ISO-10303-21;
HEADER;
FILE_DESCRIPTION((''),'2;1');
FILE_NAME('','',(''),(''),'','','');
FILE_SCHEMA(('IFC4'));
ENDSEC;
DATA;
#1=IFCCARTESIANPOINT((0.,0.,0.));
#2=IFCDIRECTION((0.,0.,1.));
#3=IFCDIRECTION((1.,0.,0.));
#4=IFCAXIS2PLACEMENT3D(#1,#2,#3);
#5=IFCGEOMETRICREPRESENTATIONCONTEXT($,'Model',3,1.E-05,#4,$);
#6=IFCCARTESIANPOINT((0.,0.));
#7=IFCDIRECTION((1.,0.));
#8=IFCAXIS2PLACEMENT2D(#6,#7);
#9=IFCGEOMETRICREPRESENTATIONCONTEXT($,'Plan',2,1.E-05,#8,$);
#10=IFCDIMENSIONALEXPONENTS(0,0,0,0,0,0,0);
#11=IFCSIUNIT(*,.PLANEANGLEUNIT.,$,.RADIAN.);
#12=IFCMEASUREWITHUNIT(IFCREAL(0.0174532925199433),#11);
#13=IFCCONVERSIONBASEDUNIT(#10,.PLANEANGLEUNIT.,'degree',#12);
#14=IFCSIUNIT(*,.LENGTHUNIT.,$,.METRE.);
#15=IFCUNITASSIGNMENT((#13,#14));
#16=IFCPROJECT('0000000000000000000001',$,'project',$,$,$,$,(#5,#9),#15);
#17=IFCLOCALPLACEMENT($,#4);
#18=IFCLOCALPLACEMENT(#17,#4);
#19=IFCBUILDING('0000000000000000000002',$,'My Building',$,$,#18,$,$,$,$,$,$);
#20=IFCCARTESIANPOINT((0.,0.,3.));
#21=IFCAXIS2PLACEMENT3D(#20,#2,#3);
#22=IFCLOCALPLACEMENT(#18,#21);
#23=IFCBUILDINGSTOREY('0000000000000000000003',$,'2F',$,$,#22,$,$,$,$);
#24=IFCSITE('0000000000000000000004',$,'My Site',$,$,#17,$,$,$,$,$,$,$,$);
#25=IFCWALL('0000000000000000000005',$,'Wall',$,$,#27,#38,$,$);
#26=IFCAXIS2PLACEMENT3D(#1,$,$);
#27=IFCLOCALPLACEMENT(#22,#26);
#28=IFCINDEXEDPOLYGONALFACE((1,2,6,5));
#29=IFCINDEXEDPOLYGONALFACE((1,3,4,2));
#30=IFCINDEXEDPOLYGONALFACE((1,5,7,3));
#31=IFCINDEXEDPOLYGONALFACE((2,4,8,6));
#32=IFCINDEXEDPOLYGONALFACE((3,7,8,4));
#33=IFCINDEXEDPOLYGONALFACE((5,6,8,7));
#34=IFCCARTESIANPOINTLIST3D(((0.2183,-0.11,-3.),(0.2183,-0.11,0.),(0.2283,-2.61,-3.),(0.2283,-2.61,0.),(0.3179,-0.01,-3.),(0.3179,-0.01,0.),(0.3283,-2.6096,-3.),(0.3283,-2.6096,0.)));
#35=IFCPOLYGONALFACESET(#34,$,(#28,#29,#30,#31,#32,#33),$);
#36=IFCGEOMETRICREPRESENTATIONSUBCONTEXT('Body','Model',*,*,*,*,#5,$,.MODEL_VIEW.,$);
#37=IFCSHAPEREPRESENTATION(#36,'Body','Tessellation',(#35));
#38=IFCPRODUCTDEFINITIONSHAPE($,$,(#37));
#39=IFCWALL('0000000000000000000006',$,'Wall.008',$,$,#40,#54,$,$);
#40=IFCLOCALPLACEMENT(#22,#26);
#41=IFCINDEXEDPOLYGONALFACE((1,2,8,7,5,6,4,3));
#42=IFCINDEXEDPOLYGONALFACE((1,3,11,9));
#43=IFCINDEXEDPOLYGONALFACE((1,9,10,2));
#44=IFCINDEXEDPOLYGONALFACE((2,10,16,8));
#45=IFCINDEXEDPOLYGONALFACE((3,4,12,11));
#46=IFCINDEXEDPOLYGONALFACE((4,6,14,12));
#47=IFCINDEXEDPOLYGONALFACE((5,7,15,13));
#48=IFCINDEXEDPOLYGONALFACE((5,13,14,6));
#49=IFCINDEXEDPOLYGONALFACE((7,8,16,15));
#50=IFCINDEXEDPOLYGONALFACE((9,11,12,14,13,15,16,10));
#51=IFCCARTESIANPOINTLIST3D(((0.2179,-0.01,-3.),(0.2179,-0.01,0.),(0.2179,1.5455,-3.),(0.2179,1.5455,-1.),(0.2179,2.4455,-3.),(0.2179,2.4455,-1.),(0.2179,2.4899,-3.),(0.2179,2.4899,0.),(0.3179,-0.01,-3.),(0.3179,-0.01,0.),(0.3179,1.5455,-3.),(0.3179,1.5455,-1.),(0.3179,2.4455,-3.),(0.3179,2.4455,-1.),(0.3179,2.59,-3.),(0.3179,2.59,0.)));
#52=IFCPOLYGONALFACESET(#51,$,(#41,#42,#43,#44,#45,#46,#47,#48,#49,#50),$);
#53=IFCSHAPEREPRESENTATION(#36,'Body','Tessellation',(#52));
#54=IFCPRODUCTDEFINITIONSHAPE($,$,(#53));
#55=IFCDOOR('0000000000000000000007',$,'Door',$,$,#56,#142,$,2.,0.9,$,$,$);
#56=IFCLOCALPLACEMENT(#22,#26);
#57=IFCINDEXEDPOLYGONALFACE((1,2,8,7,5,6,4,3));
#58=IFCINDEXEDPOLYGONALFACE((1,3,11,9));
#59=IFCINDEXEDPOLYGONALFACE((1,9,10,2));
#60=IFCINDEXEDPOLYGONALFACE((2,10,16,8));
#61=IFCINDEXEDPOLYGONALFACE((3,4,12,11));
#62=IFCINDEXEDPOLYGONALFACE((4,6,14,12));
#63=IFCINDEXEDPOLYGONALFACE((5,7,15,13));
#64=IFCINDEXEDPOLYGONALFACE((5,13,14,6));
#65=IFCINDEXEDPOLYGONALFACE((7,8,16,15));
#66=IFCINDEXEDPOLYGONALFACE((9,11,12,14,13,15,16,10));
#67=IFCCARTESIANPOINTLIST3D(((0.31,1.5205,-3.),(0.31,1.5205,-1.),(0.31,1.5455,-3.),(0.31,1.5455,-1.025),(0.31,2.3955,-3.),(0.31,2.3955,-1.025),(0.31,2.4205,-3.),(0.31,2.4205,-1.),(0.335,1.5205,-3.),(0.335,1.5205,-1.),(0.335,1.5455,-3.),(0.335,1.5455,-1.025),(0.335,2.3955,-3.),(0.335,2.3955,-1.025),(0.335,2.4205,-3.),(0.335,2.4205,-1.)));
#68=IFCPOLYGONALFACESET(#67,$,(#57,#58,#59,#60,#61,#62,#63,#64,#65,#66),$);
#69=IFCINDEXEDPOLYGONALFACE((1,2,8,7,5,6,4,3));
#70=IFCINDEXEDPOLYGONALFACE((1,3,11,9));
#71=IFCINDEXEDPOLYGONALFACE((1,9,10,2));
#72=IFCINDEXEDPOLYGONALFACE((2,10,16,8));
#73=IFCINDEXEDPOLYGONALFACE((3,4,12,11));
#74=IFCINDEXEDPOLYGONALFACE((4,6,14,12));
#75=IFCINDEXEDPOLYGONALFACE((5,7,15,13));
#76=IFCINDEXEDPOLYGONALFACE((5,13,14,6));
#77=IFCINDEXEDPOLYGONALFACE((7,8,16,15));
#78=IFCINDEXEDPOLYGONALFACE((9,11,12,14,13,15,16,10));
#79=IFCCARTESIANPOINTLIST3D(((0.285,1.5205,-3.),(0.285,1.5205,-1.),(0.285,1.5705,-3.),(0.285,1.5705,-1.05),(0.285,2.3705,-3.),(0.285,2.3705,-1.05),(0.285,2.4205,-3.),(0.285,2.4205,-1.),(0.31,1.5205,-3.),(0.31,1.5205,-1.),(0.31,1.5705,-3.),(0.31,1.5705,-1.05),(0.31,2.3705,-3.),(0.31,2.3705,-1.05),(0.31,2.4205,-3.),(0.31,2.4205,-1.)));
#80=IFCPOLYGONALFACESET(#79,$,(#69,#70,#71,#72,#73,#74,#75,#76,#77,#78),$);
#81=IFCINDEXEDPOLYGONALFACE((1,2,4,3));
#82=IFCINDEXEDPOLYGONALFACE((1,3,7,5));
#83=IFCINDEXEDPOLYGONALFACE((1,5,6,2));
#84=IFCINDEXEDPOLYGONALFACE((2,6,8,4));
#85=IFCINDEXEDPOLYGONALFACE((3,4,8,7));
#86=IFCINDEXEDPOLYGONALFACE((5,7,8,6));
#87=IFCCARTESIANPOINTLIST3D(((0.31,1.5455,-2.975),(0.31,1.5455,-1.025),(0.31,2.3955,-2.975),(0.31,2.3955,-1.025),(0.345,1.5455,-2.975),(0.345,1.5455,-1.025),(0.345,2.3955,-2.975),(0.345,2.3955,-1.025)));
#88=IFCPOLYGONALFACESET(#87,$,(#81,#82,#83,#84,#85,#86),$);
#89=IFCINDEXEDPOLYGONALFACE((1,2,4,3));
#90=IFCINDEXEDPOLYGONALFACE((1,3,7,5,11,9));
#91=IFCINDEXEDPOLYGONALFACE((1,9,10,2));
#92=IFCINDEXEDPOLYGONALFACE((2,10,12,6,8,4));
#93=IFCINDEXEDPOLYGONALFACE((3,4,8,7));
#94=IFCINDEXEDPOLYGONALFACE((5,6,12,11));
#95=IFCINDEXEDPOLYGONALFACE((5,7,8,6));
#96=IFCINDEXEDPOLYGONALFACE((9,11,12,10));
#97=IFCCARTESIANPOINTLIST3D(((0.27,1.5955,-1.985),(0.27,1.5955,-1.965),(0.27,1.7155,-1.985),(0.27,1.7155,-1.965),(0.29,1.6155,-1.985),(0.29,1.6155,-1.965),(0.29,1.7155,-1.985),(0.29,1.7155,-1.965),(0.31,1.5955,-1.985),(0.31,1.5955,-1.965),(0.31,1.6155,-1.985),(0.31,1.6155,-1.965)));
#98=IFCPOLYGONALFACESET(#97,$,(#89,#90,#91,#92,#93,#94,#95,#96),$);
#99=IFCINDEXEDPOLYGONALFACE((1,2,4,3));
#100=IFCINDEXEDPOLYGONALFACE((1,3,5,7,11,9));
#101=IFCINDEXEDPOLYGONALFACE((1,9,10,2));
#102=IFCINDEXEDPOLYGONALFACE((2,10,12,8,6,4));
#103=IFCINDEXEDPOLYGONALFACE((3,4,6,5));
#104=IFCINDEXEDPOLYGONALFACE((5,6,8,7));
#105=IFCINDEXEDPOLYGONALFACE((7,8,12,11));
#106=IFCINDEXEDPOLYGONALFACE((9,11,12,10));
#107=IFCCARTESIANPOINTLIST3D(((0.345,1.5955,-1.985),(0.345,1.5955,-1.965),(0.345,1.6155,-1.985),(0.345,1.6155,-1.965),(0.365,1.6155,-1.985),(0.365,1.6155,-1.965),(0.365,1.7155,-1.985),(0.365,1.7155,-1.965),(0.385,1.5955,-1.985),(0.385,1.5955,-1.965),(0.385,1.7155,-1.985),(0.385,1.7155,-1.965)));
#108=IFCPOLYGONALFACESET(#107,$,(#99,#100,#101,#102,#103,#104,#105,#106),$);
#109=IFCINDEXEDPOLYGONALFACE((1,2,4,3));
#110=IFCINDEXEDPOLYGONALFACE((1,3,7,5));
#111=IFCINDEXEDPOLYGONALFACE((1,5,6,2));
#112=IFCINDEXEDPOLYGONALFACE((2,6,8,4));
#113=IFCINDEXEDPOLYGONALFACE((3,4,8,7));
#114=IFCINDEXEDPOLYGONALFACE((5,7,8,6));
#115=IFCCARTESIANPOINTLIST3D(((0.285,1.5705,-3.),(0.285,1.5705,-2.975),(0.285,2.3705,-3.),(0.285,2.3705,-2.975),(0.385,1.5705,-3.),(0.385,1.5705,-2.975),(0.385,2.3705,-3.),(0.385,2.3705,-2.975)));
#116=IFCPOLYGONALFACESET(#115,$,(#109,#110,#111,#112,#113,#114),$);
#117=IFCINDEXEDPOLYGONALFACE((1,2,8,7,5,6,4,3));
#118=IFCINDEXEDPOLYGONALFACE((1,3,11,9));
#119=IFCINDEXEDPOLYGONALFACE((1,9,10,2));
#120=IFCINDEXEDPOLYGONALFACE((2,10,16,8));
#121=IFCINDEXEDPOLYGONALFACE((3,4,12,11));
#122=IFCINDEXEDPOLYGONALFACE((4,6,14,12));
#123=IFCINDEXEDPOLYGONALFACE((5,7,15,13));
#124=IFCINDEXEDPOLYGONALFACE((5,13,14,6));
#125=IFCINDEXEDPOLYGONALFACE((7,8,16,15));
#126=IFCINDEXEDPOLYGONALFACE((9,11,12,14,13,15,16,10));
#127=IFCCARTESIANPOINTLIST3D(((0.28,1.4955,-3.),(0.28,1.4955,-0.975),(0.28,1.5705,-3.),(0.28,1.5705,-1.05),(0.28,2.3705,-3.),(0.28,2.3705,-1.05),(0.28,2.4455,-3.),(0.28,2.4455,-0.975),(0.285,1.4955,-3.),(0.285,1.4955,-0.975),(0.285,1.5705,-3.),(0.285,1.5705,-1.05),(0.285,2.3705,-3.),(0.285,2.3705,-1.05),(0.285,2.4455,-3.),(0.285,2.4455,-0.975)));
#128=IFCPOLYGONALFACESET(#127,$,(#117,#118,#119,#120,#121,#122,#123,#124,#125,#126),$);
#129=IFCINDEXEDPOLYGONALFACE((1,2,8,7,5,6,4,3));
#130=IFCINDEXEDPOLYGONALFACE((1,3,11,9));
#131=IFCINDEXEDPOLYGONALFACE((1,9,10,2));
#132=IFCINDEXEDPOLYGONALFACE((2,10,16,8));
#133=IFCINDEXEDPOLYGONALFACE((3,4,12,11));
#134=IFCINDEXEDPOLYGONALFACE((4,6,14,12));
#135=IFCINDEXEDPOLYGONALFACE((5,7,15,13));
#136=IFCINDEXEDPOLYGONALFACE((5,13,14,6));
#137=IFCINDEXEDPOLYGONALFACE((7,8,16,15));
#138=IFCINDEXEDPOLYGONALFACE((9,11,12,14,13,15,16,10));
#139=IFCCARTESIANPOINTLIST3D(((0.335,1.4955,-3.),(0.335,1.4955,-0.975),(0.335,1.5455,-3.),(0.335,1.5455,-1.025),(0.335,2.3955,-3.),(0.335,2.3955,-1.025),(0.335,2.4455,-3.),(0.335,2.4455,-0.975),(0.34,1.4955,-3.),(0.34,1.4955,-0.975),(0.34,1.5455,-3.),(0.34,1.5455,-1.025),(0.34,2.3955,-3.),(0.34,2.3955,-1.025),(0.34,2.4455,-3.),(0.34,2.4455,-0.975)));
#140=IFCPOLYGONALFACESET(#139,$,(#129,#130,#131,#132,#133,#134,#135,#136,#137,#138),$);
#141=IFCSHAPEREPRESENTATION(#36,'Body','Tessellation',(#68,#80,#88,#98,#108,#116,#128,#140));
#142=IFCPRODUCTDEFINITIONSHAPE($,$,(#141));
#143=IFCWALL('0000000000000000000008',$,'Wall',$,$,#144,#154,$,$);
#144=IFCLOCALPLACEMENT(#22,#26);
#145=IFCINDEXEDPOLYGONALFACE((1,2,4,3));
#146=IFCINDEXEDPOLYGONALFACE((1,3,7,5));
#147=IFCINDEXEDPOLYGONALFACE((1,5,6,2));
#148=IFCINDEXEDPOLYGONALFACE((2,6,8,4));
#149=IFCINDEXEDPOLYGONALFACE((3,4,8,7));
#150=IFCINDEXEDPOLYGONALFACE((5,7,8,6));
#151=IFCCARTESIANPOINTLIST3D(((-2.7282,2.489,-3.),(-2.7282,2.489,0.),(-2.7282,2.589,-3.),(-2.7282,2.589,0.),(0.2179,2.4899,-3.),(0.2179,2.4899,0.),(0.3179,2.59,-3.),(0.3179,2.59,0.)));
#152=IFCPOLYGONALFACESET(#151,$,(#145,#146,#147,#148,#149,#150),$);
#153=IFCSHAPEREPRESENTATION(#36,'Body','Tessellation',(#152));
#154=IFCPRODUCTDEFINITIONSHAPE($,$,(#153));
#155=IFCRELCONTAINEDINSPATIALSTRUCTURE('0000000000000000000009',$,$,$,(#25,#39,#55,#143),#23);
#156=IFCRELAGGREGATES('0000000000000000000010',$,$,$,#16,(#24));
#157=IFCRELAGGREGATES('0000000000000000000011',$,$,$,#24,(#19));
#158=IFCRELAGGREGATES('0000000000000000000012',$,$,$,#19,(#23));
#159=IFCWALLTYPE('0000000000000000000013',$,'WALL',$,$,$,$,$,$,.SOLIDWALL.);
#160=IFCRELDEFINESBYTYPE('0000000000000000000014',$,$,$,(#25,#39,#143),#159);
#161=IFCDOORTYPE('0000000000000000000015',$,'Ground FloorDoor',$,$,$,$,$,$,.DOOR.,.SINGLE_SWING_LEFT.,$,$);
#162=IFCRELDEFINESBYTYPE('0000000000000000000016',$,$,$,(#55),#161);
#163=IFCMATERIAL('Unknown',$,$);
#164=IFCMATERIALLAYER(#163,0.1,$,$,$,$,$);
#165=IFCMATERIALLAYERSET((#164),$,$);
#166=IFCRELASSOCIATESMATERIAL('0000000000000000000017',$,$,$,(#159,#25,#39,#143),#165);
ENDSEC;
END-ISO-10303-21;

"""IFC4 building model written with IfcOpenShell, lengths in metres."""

from ifc_helpers import new_model, entity, si_unit, converted_unit, frame, origin_with_axes, origin_2d_with_axis, place, context, subcontext, project, spatial, line, indexed_curve, outline, extrude, shape, source, transform, mapped, material, layer, layer_set, layer_usage, type_object, type_shapes, element, fill, save


model = new_model("IFC4")

# Units and contexts
model_context = context("Model", 3, precision=1e-05, world=origin_with_axes())
plan_context = context("Plan", 2, precision=1e-05, world=origin_2d_with_axis())
body_context_1 = subcontext(model_context, "Body", "Model", "MODEL_VIEW")
body_context_2 = subcontext(plan_context, "Body", "Plan", "PLAN_VIEW")
ifc_project = project(units=[converted_unit("PLANEANGLEUNIT", "degree", entity("IfcReal", 0.0174532925199433), si_unit("PLANEANGLEUNIT", "RADIAN"), dimensions=[0, 0, 0, 0, 0, 0, 0]), si_unit("LENGTHUNIT", "METRE")], contexts=[model_context, plan_context])

# Site, building, storey
site_placement = place(None, origin_with_axes())
site = spatial("IfcSite", under=ifc_project, at=site_placement, Name="My Site")
building_placement = place(site_placement, origin_with_axes())
building = spatial("IfcBuilding", under=site, at=building_placement, Name="My Building")
storey_placement = place(building_placement, frame((0.0, 0.0, 3.0), z_axis=(0.0, 0.0, 1.0), x_axis=(1.0, 0.0, 0.0)))
storey = spatial("IfcBuildingStorey", under=building, at=storey_placement, Name="2F")

# Shared definitions
ifc_material = material(Name="Unknown")

# Shared definitions
ifc_layer_1 = layer(ifc_material, 0.1)
ifc_layer_set_1 = layer_set([ifc_layer_1])
wall_type_1 = type_object("IfcWallType", Name="WALL", PredefinedType="SOLIDWALL", material=ifc_layer_set_1)

# Wall
ifc_layer_usage_1 = layer_usage(ifc_layer_set_1, "AXIS2", "POSITIVE", 0.0)
wall_1_placement = place(storey_placement, frame((0.2183, -0.11, -3.0), z_axis=(0.0, 0.0, 1.0), x_axis=(0.004, -0.999992, 0.0)))
element("IfcWall", 1, at=wall_1_placement, inside=storey, type_object=wall_type_1, material=ifc_layer_usage_1, Name="Wall", context=body_context_1, shape_type="SweptSolid", body=[
    extrude(outline(indexed_curve([(0.0, 0.0), (-0.0996, 0.1), (2.5, 0.1), (2.5, 0.0)], segments=[line(1, 2, 3, 4, 1)])), origin_with_axes(), (0.0, 0.0, 1.0), 3.0),
])

# Wall, opening, door
ifc_layer_usage_2 = layer_usage(ifc_layer_set_1, "AXIS2", "POSITIVE", 0.0)
wall_2_placement = place(storey_placement, frame((0.3179, -0.01, -3.0), z_axis=(0.0, 0.0, 1.0), x_axis=(0.0, 1.0, 0.0)))
wall_2 = element("IfcWall", 2, at=wall_2_placement, inside=storey, type_object=wall_type_1, material=ifc_layer_usage_2, Name="Wall.008", context=body_context_1, shape_type="SweptSolid", body=[
    extrude(outline(indexed_curve([(0.0, 0.0), (0.0, 0.1), (2.5, 0.1), (2.6, 0.0)], segments=[line(1, 2, 3, 4, 1)])), origin_with_axes(), (0.0, 0.0, 1.0), 3.0),
])
shared_shape_1 = source(origin_with_axes(), body_context_1, "Body", "SweptSolid", [
    extrude(outline(indexed_curve([(0.0, 0.0), (0.9, 0.0), (0.9, 2.0), (0.0, 2.0)], segments=[line(1, 2, 3, 4, 1)])), frame((0.0, -0.6, 0.0), z_axis=(0.0, -1.0, 0.0), x_axis=(1.0, 0.0, 0.0)), (0.0, 0.0, -1.0), 1.2),
])
opening_1_placement = place(wall_2_placement, frame((1.5555, 0.0, 0.0), z_axis=(0.0, 0.0, 1.0), x_axis=(1.0, 0.0, 0.0)))
opening_1 = element("IfcOpeningElement", 3, at=opening_1_placement, cuts=wall_2, PredefinedType="OPENING", context=body_context_1, shape_type="MappedRepresentation", body=[
    mapped(shared_shape_1, transform((0.0, 0.0, 0.0), x_axis=(1.0, 0.0, 0.0), y_axis=(0.0, 1.0, 0.0), z_axis=(0.0, 0.0, 1.0), scale=1.0)),
])
door_type_1 = type_object("IfcDoorType", Name="Ground FloorDoor", OperationType="SINGLE_SWING_LEFT", PredefinedType="DOOR")
shared_shape_2 = source(origin_with_axes(), body_context_1, "Body", "SweptSolid", [
    extrude(outline(indexed_curve([(0.0, 0.0), (0.0, 2.0), (0.9, 2.0), (0.9, 0.0), (0.875, 0.0), (0.875, 1.975), (0.025, 1.975), (0.025, 0.0)], segments=[line(1, 2, 3, 4, 5, 6, 7, 8, 1)])), frame((0.0, 0.025, 0.0), z_axis=(0.0, -1.0, 0.0), x_axis=(1.0, 0.0, 0.0)), (0.0, 0.0, -1.0), 0.025),
    extrude(outline(indexed_curve([(0.0, 0.0), (0.0, 2.0), (0.9, 2.0), (0.9, 0.0), (0.85, 0.0), (0.85, 1.95), (0.05, 1.95), (0.05, 0.0)], segments=[line(1, 2, 3, 4, 5, 6, 7, 8, 1)])), frame((0.0, 0.0, 0.0), z_axis=(0.0, -1.0, 0.0), x_axis=(1.0, 0.0, 0.0)), (0.0, 0.0, -1.0), 0.025),
    extrude(outline(indexed_curve([(0.0, 0.0), (0.85, 0.0), (0.85, 0.035), (0.0, 0.035)], segments=[line(1, 2, 3, 4, 1)])), frame((0.025, 0.025, 0.025), z_axis=(0.0, 0.0, 1.0), x_axis=(1.0, 0.0, 0.0)), (0.0, 0.0, 1.0), 1.95),
    extrude(outline(indexed_curve([(0.0, 0.0), (0.0, -0.04), (-0.12, -0.04), (-0.12, -0.02), (-0.02, -0.02), (-0.02, 0.0)], segments=[line(1, 2, 3, 4, 5, 6, 1)])), frame((0.825, 0.025, 1.015), z_axis=(0.0, 0.0, 1.0), x_axis=(1.0, 0.0, 0.0)), (0.0, 0.0, 1.0), 0.02),
    extrude(outline(indexed_curve([(0.0, 0.0), (0.0, 0.04), (-0.12, 0.04), (-0.12, 0.02), (-0.02, 0.02), (-0.02, 0.0)], segments=[line(1, 2, 3, 4, 5, 6, 1)])), frame((0.825, 0.06, 1.015), z_axis=(0.0, 0.0, 1.0), x_axis=(1.0, 0.0, 0.0)), (0.0, 0.0, 1.0), 0.02),
    extrude(outline(indexed_curve([(0.0, 0.0), (0.8, 0.0), (0.8, 0.1), (0.0, 0.1)], segments=[line(1, 2, 3, 4, 1)])), frame((0.05, 0.0, 0.0), z_axis=(0.0, 0.0, 1.0), x_axis=(1.0, 0.0, 0.0)), (0.0, 0.0, 1.0), 0.025),
    extrude(outline(indexed_curve([(0.0, 0.0), (0.0, 2.025), (0.95, 2.025), (0.95, 0.0), (0.875, 0.0), (0.875, 1.95), (0.075, 1.95), (0.075, 0.0)], segments=[line(1, 2, 3, 4, 5, 6, 7, 8, 1)])), frame((-0.025, -0.005, 0.0), z_axis=(0.0, -1.0, 0.0), x_axis=(1.0, 0.0, 0.0)), (0.0, 0.0, -1.0), 0.005),
    extrude(outline(indexed_curve([(0.0, 0.0), (0.0, 2.025), (0.95, 2.025), (0.95, 0.0), (0.9, 0.0), (0.9, 1.975), (0.05, 1.975), (0.05, 0.0)], segments=[line(1, 2, 3, 4, 5, 6, 7, 8, 1)])), frame((-0.025, 0.05, 0.0), z_axis=(0.0, -1.0, 0.0), x_axis=(1.0, 0.0, 0.0)), (0.0, 0.0, -1.0), 0.005),
])
shared_shape_3 = source(origin_with_axes(), body_context_2, "Body", "Curve2D", [
    entity("IfcIndexedPolyCurve", entity("IfcCartesianPointList2D", [[0.0, 0.0], [0.0, 0.05], [0.025, 0.05], [0.025, 0.025], [0.05, 0.025], [0.05, 0.0]]), [entity("IfcLineIndex", [1, 2, 3, 4, 5, 6, 1])]),
    entity("IfcIndexedPolyCurve", entity("IfcCartesianPointList2D", [[0.9, 0.0], [0.9, 0.05], [0.875, 0.05], [0.875, 0.025], [0.85, 0.025], [0.85, 0.0]]), [entity("IfcLineIndex", [1, 2, 3, 4, 5, 6, 1])]),
    entity("IfcTrimmedCurve", entity("IfcEllipse", entity("IfcAxis2Placement2D", entity("IfcCartesianPoint", [0.06, 0.05]), entity("IfcDirection", [1.0, 0.0])), 0.815, 0.85), [entity("IfcCartesianPoint", [0.875, 0.05])], [entity("IfcCartesianPoint", [0.06, 0.9])], True, "CARTESIAN"),
    entity("IfcIndexedPolyCurve", entity("IfcCartesianPointList2D", [[0.025, 0.05], [0.06, 0.05], [0.06, 0.9], [0.025, 0.9]]), [entity("IfcLineIndex", [1, 2, 3, 4, 1])]),
])
type_shapes(door_type_1, [shared_shape_2, shared_shape_3])
door_1_placement = place(opening_1_placement, frame((0.875, 0.033, 0.0), z_axis=(0.0, 0.0, 1.0), x_axis=(-1.0, 0.0, 0.0)))
door_1 = element("IfcDoor", 4, at=door_1_placement, inside=storey, type_object=door_type_1, Name="Door", OverallHeight=2.0, OverallWidth=0.9, shapes=[
    shape(body_context_1, "Body", "MappedRepresentation", [mapped(shared_shape_2, transform((0.0, 0.0, 0.0), x_axis=(1.0, 0.0, 0.0), y_axis=(0.0, 1.0, 0.0), z_axis=(0.0, 0.0, 1.0), scale=1.0))]),
    shape(body_context_2, "Body", "MappedRepresentation", [mapped(shared_shape_3, transform((0.0, 0.0, 0.0), x_axis=(1.0, 0.0, 0.0), y_axis=(0.0, 1.0, 0.0), z_axis=(0.0, 0.0, 1.0), scale=1.0))]),
])
fill(opening_1, door_1)

# Wall
ifc_layer_usage_3 = layer_usage(ifc_layer_set_1, "AXIS2", "POSITIVE", 0.0)
wall_3_placement = place(storey_placement, frame((0.3179, 2.59, -3.0), z_axis=(0.0, 0.0, 1.0), x_axis=(-1.0, -0.000321, 0.0)))
element("IfcWall", 5, at=wall_3_placement, inside=storey, type_object=wall_type_1, material=ifc_layer_usage_3, Name="Wall", context=body_context_1, shape_type="SweptSolid", body=[
    extrude(outline(indexed_curve([(0.0, 0.0), (0.1, 0.1), (3.0462, 0.1), (3.0462, 0.0)], segments=[line(1, 2, 3, 4, 1)])), origin_with_axes(), (0.0, 0.0, 1.0), 3.0),
])

save(model, "model.ifc")
